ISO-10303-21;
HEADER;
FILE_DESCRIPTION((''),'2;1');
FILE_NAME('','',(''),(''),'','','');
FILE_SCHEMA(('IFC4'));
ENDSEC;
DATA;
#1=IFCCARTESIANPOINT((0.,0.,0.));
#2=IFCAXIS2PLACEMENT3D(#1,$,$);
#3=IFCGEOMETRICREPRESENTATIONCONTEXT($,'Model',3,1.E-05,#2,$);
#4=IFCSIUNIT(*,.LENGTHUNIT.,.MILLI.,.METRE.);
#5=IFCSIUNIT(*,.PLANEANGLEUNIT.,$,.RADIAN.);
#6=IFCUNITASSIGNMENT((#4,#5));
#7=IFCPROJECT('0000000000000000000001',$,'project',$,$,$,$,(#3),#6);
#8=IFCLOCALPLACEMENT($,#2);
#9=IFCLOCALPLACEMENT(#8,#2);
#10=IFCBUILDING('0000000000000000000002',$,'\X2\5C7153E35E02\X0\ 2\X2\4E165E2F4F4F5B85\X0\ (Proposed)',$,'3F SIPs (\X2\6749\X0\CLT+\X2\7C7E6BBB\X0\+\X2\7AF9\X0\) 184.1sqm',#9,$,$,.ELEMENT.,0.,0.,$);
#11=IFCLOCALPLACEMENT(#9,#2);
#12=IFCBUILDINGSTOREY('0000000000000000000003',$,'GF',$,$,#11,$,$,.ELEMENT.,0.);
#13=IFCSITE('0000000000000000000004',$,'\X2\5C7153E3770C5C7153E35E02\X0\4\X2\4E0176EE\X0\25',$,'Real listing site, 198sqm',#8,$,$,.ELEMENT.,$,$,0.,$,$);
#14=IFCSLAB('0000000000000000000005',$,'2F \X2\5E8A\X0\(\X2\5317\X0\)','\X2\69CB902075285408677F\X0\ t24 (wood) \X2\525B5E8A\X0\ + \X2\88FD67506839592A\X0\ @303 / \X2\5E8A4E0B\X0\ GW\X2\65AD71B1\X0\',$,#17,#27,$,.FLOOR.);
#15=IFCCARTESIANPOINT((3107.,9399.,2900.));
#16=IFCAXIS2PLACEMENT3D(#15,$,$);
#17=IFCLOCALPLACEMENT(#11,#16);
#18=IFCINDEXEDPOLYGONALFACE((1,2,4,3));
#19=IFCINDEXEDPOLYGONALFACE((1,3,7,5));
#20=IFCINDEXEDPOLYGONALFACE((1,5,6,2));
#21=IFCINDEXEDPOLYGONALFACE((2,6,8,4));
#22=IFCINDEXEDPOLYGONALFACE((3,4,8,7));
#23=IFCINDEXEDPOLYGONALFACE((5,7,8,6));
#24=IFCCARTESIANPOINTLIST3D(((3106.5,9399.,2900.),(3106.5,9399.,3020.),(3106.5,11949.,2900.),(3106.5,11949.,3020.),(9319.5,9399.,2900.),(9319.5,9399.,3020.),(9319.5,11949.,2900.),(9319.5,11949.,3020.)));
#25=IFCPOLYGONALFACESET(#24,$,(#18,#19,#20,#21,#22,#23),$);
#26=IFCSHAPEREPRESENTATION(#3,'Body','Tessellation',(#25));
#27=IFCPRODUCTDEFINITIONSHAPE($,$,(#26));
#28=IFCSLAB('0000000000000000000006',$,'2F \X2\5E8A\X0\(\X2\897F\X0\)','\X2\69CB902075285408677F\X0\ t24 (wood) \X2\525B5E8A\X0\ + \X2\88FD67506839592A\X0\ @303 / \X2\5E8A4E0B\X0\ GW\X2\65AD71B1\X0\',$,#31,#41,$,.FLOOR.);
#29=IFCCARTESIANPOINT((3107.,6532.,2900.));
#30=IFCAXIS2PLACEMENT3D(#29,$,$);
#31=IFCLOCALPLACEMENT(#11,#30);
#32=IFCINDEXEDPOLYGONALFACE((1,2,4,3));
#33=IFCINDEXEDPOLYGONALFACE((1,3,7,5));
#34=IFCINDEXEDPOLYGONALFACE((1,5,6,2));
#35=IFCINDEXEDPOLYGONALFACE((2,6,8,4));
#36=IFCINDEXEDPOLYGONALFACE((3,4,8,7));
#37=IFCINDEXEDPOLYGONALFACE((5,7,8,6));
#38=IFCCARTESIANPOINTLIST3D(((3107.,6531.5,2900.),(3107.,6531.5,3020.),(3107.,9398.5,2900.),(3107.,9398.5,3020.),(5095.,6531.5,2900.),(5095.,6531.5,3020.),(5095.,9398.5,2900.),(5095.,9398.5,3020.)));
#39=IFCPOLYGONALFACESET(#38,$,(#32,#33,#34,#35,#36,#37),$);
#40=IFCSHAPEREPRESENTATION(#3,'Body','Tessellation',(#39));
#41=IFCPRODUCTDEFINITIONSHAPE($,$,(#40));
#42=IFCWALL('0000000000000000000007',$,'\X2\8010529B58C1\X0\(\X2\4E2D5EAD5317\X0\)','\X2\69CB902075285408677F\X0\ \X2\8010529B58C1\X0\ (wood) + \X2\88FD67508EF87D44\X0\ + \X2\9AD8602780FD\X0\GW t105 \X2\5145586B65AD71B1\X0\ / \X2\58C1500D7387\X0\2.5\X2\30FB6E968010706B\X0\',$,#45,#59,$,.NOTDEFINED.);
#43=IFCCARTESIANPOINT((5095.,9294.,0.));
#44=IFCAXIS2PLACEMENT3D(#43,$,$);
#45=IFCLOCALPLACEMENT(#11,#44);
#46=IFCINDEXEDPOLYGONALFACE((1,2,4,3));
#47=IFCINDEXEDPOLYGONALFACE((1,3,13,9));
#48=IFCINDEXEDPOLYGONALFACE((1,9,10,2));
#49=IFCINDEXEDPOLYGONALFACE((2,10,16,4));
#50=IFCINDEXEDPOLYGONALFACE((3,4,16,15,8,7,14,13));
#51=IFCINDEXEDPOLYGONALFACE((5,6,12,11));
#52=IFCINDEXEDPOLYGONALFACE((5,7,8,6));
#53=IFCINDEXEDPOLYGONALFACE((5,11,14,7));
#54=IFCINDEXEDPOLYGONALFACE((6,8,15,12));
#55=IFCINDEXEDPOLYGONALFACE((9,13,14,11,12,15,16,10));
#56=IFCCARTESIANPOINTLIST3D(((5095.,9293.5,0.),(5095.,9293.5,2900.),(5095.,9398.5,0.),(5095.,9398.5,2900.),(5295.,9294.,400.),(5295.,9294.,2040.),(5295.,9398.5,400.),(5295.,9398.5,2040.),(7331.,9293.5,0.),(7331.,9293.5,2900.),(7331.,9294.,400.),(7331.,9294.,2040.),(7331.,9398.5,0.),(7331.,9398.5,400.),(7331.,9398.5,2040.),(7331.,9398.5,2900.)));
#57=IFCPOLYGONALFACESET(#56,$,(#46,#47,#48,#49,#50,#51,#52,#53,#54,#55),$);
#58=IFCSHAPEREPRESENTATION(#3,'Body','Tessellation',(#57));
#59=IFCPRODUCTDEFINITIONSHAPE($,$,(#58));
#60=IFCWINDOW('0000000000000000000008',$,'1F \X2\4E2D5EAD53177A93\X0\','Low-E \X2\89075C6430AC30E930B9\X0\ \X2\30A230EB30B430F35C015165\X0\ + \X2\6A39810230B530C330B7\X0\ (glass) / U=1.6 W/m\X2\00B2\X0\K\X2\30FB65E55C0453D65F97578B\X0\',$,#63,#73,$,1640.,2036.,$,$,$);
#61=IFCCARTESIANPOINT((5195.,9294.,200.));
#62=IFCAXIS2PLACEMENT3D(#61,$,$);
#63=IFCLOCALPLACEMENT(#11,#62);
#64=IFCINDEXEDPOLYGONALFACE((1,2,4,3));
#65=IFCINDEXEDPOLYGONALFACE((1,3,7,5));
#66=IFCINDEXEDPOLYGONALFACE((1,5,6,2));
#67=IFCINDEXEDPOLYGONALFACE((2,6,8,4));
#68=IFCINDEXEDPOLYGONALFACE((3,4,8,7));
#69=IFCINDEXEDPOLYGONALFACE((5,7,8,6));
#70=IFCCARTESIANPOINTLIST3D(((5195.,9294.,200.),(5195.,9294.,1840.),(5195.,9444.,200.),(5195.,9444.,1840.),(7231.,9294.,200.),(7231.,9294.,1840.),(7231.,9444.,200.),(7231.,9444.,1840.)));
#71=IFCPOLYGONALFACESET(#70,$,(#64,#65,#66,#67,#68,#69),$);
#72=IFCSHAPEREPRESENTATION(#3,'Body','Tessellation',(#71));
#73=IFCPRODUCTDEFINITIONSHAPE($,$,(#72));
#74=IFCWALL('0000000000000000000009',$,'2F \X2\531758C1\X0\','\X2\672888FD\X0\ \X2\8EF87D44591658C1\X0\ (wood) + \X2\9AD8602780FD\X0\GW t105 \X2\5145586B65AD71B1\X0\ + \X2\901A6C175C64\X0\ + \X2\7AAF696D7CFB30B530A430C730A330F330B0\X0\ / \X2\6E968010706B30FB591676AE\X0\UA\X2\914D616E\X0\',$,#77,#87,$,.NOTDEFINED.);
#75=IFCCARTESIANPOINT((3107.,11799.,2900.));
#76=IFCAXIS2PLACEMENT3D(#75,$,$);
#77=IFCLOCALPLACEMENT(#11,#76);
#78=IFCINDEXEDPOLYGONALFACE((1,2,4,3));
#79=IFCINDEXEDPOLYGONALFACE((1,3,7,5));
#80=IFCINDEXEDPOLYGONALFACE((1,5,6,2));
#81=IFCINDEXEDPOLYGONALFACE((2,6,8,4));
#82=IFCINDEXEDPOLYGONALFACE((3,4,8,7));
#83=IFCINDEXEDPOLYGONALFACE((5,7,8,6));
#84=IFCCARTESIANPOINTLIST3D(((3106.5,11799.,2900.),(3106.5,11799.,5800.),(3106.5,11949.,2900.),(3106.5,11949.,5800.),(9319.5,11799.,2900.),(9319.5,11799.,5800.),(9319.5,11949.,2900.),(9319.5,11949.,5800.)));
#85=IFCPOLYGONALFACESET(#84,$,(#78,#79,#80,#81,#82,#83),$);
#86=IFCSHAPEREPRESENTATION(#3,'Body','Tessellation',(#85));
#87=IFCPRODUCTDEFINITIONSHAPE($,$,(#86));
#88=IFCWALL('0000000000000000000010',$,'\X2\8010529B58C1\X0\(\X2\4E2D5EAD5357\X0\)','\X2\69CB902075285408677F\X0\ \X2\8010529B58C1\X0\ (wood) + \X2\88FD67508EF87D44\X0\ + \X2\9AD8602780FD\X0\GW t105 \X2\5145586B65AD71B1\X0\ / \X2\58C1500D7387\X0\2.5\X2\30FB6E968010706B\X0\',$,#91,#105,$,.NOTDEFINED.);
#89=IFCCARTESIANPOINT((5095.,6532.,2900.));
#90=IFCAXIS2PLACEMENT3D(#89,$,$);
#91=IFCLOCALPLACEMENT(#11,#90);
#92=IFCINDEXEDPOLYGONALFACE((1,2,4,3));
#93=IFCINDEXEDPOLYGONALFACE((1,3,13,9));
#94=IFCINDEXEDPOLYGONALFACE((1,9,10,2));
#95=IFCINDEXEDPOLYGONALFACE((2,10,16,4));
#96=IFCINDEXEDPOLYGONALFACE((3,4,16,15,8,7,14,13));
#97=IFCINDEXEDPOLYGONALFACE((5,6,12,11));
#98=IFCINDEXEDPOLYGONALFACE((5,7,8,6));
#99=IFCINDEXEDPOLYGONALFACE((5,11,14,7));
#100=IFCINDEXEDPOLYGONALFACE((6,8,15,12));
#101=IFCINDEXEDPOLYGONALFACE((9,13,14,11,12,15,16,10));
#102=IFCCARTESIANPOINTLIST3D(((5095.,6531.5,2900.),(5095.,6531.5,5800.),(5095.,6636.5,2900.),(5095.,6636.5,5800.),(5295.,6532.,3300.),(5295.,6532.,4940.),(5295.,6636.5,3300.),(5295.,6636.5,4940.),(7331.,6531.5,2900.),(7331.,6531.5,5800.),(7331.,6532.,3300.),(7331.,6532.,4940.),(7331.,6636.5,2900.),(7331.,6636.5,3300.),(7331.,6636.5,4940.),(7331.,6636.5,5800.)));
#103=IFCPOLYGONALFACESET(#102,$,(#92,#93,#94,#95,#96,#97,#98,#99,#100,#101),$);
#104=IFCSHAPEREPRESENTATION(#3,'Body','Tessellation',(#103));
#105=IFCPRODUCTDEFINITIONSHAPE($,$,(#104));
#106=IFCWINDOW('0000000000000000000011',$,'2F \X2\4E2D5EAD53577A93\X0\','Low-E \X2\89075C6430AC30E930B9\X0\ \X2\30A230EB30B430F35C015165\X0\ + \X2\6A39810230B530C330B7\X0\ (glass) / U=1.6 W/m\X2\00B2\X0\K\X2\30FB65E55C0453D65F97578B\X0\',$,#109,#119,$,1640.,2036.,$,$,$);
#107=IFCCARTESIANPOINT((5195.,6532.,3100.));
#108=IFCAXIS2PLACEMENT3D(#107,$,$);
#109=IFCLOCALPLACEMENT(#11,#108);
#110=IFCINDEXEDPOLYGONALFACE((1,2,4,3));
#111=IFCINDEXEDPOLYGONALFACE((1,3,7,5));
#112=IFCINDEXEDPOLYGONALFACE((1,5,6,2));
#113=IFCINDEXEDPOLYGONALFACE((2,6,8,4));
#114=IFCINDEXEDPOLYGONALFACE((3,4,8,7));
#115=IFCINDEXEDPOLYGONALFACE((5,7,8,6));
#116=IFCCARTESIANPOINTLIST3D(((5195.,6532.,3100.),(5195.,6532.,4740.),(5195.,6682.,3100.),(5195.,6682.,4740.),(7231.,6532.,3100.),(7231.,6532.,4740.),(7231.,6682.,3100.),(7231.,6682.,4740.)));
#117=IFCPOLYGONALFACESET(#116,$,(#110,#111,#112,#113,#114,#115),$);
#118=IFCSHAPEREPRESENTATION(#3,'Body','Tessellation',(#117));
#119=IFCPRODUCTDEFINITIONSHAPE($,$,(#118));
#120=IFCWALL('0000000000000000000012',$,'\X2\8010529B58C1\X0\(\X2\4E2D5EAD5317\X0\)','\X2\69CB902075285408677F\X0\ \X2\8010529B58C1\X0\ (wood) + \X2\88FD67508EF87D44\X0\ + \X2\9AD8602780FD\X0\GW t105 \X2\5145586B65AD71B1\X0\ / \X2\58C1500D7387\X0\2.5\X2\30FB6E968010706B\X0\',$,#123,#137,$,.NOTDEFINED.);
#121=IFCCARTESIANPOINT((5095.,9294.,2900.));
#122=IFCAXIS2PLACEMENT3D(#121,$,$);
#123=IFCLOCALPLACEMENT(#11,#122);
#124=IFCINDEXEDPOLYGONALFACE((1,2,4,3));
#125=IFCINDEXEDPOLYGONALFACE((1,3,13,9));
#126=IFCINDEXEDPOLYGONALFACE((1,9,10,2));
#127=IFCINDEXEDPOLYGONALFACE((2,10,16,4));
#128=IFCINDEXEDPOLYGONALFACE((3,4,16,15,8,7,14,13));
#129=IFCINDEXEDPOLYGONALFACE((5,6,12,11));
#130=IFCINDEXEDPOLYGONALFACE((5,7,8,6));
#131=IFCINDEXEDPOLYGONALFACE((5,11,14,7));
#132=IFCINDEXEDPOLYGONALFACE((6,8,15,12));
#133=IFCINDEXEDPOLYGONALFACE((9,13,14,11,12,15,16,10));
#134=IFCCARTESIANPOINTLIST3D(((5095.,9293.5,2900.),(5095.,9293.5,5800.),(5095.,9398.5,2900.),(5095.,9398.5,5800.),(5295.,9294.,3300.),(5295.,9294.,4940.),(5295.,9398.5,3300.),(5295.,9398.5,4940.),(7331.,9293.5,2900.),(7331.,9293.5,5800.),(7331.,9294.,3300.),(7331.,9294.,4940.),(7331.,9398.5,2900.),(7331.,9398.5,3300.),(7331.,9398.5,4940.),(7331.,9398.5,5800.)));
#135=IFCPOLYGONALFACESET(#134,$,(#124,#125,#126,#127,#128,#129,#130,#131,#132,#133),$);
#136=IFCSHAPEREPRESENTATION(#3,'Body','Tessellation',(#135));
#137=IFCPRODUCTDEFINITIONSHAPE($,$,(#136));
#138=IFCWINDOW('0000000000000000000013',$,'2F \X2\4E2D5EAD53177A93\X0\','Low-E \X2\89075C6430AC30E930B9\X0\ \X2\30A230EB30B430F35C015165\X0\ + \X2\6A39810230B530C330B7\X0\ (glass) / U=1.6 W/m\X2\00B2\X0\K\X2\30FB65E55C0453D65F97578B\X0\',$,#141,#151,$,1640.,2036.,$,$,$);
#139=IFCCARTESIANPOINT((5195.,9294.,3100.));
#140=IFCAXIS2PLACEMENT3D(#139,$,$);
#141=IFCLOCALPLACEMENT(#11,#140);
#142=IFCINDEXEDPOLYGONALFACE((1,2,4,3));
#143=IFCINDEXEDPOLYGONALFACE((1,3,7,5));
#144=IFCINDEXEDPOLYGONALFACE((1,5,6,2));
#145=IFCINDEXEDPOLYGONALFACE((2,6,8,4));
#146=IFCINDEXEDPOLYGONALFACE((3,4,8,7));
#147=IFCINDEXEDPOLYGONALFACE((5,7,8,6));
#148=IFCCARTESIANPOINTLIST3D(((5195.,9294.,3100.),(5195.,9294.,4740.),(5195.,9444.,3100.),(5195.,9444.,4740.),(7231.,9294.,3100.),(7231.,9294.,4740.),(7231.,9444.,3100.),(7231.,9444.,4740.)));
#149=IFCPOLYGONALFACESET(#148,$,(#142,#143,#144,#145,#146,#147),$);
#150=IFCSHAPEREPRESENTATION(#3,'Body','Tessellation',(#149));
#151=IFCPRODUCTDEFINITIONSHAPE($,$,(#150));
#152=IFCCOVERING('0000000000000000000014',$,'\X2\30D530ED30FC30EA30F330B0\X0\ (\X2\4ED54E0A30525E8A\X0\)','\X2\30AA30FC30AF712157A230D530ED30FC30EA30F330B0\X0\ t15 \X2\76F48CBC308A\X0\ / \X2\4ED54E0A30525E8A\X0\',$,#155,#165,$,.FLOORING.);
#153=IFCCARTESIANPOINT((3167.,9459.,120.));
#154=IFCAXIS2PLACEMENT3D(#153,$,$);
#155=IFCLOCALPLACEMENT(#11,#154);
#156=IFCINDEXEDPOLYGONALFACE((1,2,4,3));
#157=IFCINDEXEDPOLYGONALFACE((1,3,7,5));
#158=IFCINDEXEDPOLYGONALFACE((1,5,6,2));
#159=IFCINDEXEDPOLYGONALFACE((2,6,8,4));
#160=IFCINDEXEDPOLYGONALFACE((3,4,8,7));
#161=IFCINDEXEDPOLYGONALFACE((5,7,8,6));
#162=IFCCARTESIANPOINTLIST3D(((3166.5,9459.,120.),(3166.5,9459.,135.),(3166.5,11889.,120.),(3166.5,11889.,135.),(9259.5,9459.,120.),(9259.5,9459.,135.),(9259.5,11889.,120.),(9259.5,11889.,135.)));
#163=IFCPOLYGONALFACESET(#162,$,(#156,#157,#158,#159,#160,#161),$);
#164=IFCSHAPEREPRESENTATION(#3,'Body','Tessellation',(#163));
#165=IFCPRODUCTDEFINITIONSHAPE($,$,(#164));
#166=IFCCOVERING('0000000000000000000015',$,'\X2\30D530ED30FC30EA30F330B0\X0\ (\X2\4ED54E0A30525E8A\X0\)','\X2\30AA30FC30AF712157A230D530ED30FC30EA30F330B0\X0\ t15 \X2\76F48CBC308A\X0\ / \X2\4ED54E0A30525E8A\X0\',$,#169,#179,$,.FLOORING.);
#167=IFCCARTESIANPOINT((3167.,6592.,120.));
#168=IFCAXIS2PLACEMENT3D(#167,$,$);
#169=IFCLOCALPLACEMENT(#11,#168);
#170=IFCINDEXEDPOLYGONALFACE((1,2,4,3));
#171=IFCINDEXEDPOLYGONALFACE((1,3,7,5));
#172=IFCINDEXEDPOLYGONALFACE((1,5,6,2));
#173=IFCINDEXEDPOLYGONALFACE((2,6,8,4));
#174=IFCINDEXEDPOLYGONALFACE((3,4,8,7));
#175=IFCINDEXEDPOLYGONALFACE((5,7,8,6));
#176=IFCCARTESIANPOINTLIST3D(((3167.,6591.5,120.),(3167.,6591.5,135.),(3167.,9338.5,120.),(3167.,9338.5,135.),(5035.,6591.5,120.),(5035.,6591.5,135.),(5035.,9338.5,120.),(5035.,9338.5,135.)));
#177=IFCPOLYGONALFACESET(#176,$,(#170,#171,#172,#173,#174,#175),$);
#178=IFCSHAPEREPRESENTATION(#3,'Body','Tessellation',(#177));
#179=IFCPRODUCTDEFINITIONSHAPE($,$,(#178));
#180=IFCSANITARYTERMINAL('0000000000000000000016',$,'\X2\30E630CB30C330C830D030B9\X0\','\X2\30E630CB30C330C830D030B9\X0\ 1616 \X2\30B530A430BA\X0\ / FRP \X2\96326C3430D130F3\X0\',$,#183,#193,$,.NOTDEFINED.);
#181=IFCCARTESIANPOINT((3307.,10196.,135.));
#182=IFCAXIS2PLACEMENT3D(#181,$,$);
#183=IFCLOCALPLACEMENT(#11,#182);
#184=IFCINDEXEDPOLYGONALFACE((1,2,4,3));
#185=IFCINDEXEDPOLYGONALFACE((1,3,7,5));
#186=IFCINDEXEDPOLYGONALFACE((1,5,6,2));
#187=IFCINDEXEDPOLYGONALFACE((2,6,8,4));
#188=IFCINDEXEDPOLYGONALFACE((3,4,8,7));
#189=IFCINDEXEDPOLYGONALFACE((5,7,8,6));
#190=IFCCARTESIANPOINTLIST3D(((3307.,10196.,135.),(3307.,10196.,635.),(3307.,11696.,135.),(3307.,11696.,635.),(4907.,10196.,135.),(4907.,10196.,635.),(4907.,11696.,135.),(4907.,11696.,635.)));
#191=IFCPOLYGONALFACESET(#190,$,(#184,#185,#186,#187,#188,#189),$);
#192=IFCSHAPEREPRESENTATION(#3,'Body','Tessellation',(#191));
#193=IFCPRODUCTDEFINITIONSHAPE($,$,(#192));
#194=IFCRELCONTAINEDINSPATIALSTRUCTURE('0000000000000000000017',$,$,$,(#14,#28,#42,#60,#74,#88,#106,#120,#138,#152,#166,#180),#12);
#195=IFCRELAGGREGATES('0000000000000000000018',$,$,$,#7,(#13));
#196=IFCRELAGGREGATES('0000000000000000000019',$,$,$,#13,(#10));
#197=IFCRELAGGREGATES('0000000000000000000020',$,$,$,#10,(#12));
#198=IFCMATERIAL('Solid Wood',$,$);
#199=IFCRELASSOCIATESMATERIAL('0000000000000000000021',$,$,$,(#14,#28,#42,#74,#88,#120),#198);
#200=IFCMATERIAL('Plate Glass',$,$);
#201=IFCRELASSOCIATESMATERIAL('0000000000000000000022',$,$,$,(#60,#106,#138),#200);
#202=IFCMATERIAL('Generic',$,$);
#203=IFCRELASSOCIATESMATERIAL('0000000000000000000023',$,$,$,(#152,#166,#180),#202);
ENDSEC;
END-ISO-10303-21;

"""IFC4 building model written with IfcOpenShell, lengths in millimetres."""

from ifc_helpers import new_model, si_unit, frame, frame_2d, origin, place, context, project, spatial, rectangle, extrude, material, element, fill, save


model = new_model("IFC4")

# Units and contexts
model_context = context("Model", 3, precision=1e-05, world=origin())
ifc_project = project(units=[si_unit("LENGTHUNIT", "METRE", prefix="MILLI"), si_unit("PLANEANGLEUNIT", "RADIAN")], contexts=[model_context])

# Site, building, storey
site_placement = place(None, origin())
site = spatial("IfcSite", under=ifc_project, at=site_placement, Name="山口県山口市4丁目25", ObjectType="Real listing site, 198sqm", CompositionType="ELEMENT", RefElevation=0.0)
building_placement = place(site_placement, origin())
building = spatial("IfcBuilding", under=site, at=building_placement, Name="山口市 2世帯住宅 (Proposed)", ObjectType="3F SIPs (杉CLT+籾殻+竹) 184.1sqm", CompositionType="ELEMENT", ElevationOfRefHeight=0.0, ElevationOfTerrain=0.0)
storey_placement = place(building_placement, origin())
storey = spatial("IfcBuildingStorey", under=building, at=storey_placement, Name="GF", CompositionType="ELEMENT", Elevation=0.0)

# Slabs
ifc_material_1 = material(Name="Solid Wood")
slab_1_placement = place(storey_placement, frame((3107.0, 9399.0, 2900.0)))
element("IfcSlab", 1, at=slab_1_placement, inside=storey, material=ifc_material_1, Name="2F 床(北)", Description="構造用合板 t24 (wood) 剛床 + 製材根太 @303 / 床下 GW断熱", PredefinedType="FLOOR", context=model_context, shape_type="SweptSolid", body=[
    extrude(rectangle(XDim=6213.0, YDim=2550.0, at=frame_2d((3106.0, 1275.0))), frame((3107.0, 9399.0, 2900.0)), (0.0, 0.0, 1.0), 120.0),
])
slab_2_placement = place(storey_placement, frame((3107.0, 6532.0, 2900.0)))
element("IfcSlab", 2, at=slab_2_placement, inside=storey, material=ifc_material_1, Name="2F 床(西)", Description="構造用合板 t24 (wood) 剛床 + 製材根太 @303 / 床下 GW断熱", PredefinedType="FLOOR", context=model_context, shape_type="SweptSolid", body=[
    extrude(rectangle(XDim=1988.0, YDim=2867.0, at=frame_2d((994.0, 1433.0))), frame((3107.0, 6532.0, 2900.0)), (0.0, 0.0, 1.0), 120.0),
])

# Wall, opening, window
wall_1_placement = place(storey_placement, frame((5095.0, 9294.0, 0.0)))
wall_1 = element("IfcWall", 3, at=wall_1_placement, inside=storey, material=ifc_material_1, Name="耐力壁(中庭北)", Description="構造用合板 耐力壁 (wood) + 製材軸組 + 高性能GW t105 充填断熱 / 壁倍率2.5・準耐火", PredefinedType="NOTDEFINED", context=model_context, shape_type="SweptSolid", body=[
    extrude(rectangle(XDim=2236.0, YDim=105.0, at=frame_2d((1118.0, 52.0))), frame((5095.0, 9294.0, 0.0)), (0.0, 0.0, 1.0), 2900.0),
])
opening_1_placement = place(storey_placement, frame((5195.0, 9294.0, 200.0)))
opening_1 = element("IfcOpeningElement", 4, at=opening_1_placement, cuts=wall_1, PredefinedType="NOTDEFINED", context=model_context, shape_type="SweptSolid", body=[
    extrude(rectangle(XDim=2036.0, YDim=150.0, at=frame_2d((1018.0, 75.0))), frame((5195.0, 9294.0, 200.0)), (0.0, 0.0, 1.0), 1640.0),
])
ifc_material_2 = material(Name="Plate Glass")
window_1_placement = place(storey_placement, frame((5195.0, 9294.0, 200.0)))
window_1 = element("IfcWindow", 5, at=window_1_placement, inside=storey, material=ifc_material_2, Name="1F 中庭北窓", Description="Low-E 複層ガラス アルゴン封入 + 樹脂サッシ (glass) / U=1.6 W/m²K・日射取得型", OverallHeight=1640.0, OverallWidth=2036.0, context=model_context, shape_type="SweptSolid", body=[
    extrude(rectangle(XDim=2036.0, YDim=150.0, at=frame_2d((1018.0, 75.0))), frame((5195.0, 9294.0, 200.0)), (0.0, 0.0, 1.0), 1640.0),
])
fill(opening_1, window_1)

# Wall
wall_2_placement = place(storey_placement, frame((3107.0, 11799.0, 2900.0)))
element("IfcWall", 6, at=wall_2_placement, inside=storey, material=ifc_material_1, Name="2F 北壁", Description="木製 軸組外壁 (wood) + 高性能GW t105 充填断熱 + 通気層 + 窯業系サイディング / 準耐火・外皮UA配慮", PredefinedType="NOTDEFINED", context=model_context, shape_type="SweptSolid", body=[
    extrude(rectangle(XDim=6213.0, YDim=150.0, at=frame_2d((3106.0, 75.0))), frame((3107.0, 11799.0, 2900.0)), (0.0, 0.0, 1.0), 2900.0),
])

# Walls, openings, windows
wall_3_placement = place(storey_placement, frame((5095.0, 6532.0, 2900.0)))
wall_3 = element("IfcWall", 7, at=wall_3_placement, inside=storey, material=ifc_material_1, Name="耐力壁(中庭南)", Description="構造用合板 耐力壁 (wood) + 製材軸組 + 高性能GW t105 充填断熱 / 壁倍率2.5・準耐火", PredefinedType="NOTDEFINED", context=model_context, shape_type="SweptSolid", body=[
    extrude(rectangle(XDim=2236.0, YDim=105.0, at=frame_2d((1118.0, 52.0))), frame((5095.0, 6532.0, 2900.0)), (0.0, 0.0, 1.0), 2900.0),
])
opening_2_placement = place(storey_placement, frame((5195.0, 6532.0, 3100.0)))
opening_2 = element("IfcOpeningElement", 8, at=opening_2_placement, cuts=wall_3, PredefinedType="NOTDEFINED", context=model_context, shape_type="SweptSolid", body=[
    extrude(rectangle(XDim=2036.0, YDim=150.0, at=frame_2d((1018.0, 75.0))), frame((5195.0, 6532.0, 3100.0)), (0.0, 0.0, 1.0), 1640.0),
])
window_2_placement = place(storey_placement, frame((5195.0, 6532.0, 3100.0)))
window_2 = element("IfcWindow", 9, at=window_2_placement, inside=storey, material=ifc_material_2, Name="2F 中庭南窓", Description="Low-E 複層ガラス アルゴン封入 + 樹脂サッシ (glass) / U=1.6 W/m²K・日射取得型", OverallHeight=1640.0, OverallWidth=2036.0, context=model_context, shape_type="SweptSolid", body=[
    extrude(rectangle(XDim=2036.0, YDim=150.0, at=frame_2d((1018.0, 75.0))), frame((5195.0, 6532.0, 3100.0)), (0.0, 0.0, 1.0), 1640.0),
])
fill(opening_2, window_2)
wall_4_placement = place(storey_placement, frame((5095.0, 9294.0, 2900.0)))
wall_4 = element("IfcWall", 10, at=wall_4_placement, inside=storey, material=ifc_material_1, Name="耐力壁(中庭北)", Description="構造用合板 耐力壁 (wood) + 製材軸組 + 高性能GW t105 充填断熱 / 壁倍率2.5・準耐火", PredefinedType="NOTDEFINED", context=model_context, shape_type="SweptSolid", body=[
    extrude(rectangle(XDim=2236.0, YDim=105.0, at=frame_2d((1118.0, 52.0))), frame((5095.0, 9294.0, 2900.0)), (0.0, 0.0, 1.0), 2900.0),
])
opening_3_placement = place(storey_placement, frame((5195.0, 9294.0, 3100.0)))
opening_3 = element("IfcOpeningElement", 11, at=opening_3_placement, cuts=wall_4, PredefinedType="NOTDEFINED", context=model_context, shape_type="SweptSolid", body=[
    extrude(rectangle(XDim=2036.0, YDim=150.0, at=frame_2d((1018.0, 75.0))), frame((5195.0, 9294.0, 3100.0)), (0.0, 0.0, 1.0), 1640.0),
])
window_3_placement = place(storey_placement, frame((5195.0, 9294.0, 3100.0)))
window_3 = element("IfcWindow", 12, at=window_3_placement, inside=storey, material=ifc_material_2, Name="2F 中庭北窓", Description="Low-E 複層ガラス アルゴン封入 + 樹脂サッシ (glass) / U=1.6 W/m²K・日射取得型", OverallHeight=1640.0, OverallWidth=2036.0, context=model_context, shape_type="SweptSolid", body=[
    extrude(rectangle(XDim=2036.0, YDim=150.0, at=frame_2d((1018.0, 75.0))), frame((5195.0, 9294.0, 3100.0)), (0.0, 0.0, 1.0), 1640.0),
])
fill(opening_3, window_3)

# Coverings
ifc_material_3 = material(Name="Generic")
covering_1_placement = place(storey_placement, frame((3167.0, 9459.0, 120.0)))
element("IfcCovering", 13, at=covering_1_placement, inside=storey, material=ifc_material_3, Name="フローリング (仕上げ床)", Description="オーク無垢フローリング t15 直貼り / 仕上げ床", PredefinedType="FLOORING", context=model_context, shape_type="SweptSolid", body=[
    extrude(rectangle(XDim=6093.0, YDim=2430.0, at=frame_2d((3046.0, 1215.0))), frame((3167.0, 9459.0, 120.0)), (0.0, 0.0, 1.0), 15.0),
])
covering_2_placement = place(storey_placement, frame((3167.0, 6592.0, 120.0)))
element("IfcCovering", 14, at=covering_2_placement, inside=storey, material=ifc_material_3, Name="フローリング (仕上げ床)", Description="オーク無垢フローリング t15 直貼り / 仕上げ床", PredefinedType="FLOORING", context=model_context, shape_type="SweptSolid", body=[
    extrude(rectangle(XDim=1868.0, YDim=2747.0, at=frame_2d((934.0, 1373.0))), frame((3167.0, 6592.0, 120.0)), (0.0, 0.0, 1.0), 15.0),
])

# Sanitary terminal
sanitary_terminal_1_placement = place(storey_placement, frame((3307.0, 10196.0, 135.0)))
element("IfcSanitaryTerminal", 15, at=sanitary_terminal_1_placement, inside=storey, material=ifc_material_3, Name="ユニットバス", Description="ユニットバス 1616 サイズ / FRP 防水パン", PredefinedType="NOTDEFINED", context=model_context, shape_type="SweptSolid", body=[
    extrude(rectangle(XDim=1600.0, YDim=1500.0, at=frame_2d((800.0, 750.0))), frame((3307.0, 10196.0, 135.0)), (0.0, 0.0, 1.0), 500.0),
])

save(model, "model.ifc")
